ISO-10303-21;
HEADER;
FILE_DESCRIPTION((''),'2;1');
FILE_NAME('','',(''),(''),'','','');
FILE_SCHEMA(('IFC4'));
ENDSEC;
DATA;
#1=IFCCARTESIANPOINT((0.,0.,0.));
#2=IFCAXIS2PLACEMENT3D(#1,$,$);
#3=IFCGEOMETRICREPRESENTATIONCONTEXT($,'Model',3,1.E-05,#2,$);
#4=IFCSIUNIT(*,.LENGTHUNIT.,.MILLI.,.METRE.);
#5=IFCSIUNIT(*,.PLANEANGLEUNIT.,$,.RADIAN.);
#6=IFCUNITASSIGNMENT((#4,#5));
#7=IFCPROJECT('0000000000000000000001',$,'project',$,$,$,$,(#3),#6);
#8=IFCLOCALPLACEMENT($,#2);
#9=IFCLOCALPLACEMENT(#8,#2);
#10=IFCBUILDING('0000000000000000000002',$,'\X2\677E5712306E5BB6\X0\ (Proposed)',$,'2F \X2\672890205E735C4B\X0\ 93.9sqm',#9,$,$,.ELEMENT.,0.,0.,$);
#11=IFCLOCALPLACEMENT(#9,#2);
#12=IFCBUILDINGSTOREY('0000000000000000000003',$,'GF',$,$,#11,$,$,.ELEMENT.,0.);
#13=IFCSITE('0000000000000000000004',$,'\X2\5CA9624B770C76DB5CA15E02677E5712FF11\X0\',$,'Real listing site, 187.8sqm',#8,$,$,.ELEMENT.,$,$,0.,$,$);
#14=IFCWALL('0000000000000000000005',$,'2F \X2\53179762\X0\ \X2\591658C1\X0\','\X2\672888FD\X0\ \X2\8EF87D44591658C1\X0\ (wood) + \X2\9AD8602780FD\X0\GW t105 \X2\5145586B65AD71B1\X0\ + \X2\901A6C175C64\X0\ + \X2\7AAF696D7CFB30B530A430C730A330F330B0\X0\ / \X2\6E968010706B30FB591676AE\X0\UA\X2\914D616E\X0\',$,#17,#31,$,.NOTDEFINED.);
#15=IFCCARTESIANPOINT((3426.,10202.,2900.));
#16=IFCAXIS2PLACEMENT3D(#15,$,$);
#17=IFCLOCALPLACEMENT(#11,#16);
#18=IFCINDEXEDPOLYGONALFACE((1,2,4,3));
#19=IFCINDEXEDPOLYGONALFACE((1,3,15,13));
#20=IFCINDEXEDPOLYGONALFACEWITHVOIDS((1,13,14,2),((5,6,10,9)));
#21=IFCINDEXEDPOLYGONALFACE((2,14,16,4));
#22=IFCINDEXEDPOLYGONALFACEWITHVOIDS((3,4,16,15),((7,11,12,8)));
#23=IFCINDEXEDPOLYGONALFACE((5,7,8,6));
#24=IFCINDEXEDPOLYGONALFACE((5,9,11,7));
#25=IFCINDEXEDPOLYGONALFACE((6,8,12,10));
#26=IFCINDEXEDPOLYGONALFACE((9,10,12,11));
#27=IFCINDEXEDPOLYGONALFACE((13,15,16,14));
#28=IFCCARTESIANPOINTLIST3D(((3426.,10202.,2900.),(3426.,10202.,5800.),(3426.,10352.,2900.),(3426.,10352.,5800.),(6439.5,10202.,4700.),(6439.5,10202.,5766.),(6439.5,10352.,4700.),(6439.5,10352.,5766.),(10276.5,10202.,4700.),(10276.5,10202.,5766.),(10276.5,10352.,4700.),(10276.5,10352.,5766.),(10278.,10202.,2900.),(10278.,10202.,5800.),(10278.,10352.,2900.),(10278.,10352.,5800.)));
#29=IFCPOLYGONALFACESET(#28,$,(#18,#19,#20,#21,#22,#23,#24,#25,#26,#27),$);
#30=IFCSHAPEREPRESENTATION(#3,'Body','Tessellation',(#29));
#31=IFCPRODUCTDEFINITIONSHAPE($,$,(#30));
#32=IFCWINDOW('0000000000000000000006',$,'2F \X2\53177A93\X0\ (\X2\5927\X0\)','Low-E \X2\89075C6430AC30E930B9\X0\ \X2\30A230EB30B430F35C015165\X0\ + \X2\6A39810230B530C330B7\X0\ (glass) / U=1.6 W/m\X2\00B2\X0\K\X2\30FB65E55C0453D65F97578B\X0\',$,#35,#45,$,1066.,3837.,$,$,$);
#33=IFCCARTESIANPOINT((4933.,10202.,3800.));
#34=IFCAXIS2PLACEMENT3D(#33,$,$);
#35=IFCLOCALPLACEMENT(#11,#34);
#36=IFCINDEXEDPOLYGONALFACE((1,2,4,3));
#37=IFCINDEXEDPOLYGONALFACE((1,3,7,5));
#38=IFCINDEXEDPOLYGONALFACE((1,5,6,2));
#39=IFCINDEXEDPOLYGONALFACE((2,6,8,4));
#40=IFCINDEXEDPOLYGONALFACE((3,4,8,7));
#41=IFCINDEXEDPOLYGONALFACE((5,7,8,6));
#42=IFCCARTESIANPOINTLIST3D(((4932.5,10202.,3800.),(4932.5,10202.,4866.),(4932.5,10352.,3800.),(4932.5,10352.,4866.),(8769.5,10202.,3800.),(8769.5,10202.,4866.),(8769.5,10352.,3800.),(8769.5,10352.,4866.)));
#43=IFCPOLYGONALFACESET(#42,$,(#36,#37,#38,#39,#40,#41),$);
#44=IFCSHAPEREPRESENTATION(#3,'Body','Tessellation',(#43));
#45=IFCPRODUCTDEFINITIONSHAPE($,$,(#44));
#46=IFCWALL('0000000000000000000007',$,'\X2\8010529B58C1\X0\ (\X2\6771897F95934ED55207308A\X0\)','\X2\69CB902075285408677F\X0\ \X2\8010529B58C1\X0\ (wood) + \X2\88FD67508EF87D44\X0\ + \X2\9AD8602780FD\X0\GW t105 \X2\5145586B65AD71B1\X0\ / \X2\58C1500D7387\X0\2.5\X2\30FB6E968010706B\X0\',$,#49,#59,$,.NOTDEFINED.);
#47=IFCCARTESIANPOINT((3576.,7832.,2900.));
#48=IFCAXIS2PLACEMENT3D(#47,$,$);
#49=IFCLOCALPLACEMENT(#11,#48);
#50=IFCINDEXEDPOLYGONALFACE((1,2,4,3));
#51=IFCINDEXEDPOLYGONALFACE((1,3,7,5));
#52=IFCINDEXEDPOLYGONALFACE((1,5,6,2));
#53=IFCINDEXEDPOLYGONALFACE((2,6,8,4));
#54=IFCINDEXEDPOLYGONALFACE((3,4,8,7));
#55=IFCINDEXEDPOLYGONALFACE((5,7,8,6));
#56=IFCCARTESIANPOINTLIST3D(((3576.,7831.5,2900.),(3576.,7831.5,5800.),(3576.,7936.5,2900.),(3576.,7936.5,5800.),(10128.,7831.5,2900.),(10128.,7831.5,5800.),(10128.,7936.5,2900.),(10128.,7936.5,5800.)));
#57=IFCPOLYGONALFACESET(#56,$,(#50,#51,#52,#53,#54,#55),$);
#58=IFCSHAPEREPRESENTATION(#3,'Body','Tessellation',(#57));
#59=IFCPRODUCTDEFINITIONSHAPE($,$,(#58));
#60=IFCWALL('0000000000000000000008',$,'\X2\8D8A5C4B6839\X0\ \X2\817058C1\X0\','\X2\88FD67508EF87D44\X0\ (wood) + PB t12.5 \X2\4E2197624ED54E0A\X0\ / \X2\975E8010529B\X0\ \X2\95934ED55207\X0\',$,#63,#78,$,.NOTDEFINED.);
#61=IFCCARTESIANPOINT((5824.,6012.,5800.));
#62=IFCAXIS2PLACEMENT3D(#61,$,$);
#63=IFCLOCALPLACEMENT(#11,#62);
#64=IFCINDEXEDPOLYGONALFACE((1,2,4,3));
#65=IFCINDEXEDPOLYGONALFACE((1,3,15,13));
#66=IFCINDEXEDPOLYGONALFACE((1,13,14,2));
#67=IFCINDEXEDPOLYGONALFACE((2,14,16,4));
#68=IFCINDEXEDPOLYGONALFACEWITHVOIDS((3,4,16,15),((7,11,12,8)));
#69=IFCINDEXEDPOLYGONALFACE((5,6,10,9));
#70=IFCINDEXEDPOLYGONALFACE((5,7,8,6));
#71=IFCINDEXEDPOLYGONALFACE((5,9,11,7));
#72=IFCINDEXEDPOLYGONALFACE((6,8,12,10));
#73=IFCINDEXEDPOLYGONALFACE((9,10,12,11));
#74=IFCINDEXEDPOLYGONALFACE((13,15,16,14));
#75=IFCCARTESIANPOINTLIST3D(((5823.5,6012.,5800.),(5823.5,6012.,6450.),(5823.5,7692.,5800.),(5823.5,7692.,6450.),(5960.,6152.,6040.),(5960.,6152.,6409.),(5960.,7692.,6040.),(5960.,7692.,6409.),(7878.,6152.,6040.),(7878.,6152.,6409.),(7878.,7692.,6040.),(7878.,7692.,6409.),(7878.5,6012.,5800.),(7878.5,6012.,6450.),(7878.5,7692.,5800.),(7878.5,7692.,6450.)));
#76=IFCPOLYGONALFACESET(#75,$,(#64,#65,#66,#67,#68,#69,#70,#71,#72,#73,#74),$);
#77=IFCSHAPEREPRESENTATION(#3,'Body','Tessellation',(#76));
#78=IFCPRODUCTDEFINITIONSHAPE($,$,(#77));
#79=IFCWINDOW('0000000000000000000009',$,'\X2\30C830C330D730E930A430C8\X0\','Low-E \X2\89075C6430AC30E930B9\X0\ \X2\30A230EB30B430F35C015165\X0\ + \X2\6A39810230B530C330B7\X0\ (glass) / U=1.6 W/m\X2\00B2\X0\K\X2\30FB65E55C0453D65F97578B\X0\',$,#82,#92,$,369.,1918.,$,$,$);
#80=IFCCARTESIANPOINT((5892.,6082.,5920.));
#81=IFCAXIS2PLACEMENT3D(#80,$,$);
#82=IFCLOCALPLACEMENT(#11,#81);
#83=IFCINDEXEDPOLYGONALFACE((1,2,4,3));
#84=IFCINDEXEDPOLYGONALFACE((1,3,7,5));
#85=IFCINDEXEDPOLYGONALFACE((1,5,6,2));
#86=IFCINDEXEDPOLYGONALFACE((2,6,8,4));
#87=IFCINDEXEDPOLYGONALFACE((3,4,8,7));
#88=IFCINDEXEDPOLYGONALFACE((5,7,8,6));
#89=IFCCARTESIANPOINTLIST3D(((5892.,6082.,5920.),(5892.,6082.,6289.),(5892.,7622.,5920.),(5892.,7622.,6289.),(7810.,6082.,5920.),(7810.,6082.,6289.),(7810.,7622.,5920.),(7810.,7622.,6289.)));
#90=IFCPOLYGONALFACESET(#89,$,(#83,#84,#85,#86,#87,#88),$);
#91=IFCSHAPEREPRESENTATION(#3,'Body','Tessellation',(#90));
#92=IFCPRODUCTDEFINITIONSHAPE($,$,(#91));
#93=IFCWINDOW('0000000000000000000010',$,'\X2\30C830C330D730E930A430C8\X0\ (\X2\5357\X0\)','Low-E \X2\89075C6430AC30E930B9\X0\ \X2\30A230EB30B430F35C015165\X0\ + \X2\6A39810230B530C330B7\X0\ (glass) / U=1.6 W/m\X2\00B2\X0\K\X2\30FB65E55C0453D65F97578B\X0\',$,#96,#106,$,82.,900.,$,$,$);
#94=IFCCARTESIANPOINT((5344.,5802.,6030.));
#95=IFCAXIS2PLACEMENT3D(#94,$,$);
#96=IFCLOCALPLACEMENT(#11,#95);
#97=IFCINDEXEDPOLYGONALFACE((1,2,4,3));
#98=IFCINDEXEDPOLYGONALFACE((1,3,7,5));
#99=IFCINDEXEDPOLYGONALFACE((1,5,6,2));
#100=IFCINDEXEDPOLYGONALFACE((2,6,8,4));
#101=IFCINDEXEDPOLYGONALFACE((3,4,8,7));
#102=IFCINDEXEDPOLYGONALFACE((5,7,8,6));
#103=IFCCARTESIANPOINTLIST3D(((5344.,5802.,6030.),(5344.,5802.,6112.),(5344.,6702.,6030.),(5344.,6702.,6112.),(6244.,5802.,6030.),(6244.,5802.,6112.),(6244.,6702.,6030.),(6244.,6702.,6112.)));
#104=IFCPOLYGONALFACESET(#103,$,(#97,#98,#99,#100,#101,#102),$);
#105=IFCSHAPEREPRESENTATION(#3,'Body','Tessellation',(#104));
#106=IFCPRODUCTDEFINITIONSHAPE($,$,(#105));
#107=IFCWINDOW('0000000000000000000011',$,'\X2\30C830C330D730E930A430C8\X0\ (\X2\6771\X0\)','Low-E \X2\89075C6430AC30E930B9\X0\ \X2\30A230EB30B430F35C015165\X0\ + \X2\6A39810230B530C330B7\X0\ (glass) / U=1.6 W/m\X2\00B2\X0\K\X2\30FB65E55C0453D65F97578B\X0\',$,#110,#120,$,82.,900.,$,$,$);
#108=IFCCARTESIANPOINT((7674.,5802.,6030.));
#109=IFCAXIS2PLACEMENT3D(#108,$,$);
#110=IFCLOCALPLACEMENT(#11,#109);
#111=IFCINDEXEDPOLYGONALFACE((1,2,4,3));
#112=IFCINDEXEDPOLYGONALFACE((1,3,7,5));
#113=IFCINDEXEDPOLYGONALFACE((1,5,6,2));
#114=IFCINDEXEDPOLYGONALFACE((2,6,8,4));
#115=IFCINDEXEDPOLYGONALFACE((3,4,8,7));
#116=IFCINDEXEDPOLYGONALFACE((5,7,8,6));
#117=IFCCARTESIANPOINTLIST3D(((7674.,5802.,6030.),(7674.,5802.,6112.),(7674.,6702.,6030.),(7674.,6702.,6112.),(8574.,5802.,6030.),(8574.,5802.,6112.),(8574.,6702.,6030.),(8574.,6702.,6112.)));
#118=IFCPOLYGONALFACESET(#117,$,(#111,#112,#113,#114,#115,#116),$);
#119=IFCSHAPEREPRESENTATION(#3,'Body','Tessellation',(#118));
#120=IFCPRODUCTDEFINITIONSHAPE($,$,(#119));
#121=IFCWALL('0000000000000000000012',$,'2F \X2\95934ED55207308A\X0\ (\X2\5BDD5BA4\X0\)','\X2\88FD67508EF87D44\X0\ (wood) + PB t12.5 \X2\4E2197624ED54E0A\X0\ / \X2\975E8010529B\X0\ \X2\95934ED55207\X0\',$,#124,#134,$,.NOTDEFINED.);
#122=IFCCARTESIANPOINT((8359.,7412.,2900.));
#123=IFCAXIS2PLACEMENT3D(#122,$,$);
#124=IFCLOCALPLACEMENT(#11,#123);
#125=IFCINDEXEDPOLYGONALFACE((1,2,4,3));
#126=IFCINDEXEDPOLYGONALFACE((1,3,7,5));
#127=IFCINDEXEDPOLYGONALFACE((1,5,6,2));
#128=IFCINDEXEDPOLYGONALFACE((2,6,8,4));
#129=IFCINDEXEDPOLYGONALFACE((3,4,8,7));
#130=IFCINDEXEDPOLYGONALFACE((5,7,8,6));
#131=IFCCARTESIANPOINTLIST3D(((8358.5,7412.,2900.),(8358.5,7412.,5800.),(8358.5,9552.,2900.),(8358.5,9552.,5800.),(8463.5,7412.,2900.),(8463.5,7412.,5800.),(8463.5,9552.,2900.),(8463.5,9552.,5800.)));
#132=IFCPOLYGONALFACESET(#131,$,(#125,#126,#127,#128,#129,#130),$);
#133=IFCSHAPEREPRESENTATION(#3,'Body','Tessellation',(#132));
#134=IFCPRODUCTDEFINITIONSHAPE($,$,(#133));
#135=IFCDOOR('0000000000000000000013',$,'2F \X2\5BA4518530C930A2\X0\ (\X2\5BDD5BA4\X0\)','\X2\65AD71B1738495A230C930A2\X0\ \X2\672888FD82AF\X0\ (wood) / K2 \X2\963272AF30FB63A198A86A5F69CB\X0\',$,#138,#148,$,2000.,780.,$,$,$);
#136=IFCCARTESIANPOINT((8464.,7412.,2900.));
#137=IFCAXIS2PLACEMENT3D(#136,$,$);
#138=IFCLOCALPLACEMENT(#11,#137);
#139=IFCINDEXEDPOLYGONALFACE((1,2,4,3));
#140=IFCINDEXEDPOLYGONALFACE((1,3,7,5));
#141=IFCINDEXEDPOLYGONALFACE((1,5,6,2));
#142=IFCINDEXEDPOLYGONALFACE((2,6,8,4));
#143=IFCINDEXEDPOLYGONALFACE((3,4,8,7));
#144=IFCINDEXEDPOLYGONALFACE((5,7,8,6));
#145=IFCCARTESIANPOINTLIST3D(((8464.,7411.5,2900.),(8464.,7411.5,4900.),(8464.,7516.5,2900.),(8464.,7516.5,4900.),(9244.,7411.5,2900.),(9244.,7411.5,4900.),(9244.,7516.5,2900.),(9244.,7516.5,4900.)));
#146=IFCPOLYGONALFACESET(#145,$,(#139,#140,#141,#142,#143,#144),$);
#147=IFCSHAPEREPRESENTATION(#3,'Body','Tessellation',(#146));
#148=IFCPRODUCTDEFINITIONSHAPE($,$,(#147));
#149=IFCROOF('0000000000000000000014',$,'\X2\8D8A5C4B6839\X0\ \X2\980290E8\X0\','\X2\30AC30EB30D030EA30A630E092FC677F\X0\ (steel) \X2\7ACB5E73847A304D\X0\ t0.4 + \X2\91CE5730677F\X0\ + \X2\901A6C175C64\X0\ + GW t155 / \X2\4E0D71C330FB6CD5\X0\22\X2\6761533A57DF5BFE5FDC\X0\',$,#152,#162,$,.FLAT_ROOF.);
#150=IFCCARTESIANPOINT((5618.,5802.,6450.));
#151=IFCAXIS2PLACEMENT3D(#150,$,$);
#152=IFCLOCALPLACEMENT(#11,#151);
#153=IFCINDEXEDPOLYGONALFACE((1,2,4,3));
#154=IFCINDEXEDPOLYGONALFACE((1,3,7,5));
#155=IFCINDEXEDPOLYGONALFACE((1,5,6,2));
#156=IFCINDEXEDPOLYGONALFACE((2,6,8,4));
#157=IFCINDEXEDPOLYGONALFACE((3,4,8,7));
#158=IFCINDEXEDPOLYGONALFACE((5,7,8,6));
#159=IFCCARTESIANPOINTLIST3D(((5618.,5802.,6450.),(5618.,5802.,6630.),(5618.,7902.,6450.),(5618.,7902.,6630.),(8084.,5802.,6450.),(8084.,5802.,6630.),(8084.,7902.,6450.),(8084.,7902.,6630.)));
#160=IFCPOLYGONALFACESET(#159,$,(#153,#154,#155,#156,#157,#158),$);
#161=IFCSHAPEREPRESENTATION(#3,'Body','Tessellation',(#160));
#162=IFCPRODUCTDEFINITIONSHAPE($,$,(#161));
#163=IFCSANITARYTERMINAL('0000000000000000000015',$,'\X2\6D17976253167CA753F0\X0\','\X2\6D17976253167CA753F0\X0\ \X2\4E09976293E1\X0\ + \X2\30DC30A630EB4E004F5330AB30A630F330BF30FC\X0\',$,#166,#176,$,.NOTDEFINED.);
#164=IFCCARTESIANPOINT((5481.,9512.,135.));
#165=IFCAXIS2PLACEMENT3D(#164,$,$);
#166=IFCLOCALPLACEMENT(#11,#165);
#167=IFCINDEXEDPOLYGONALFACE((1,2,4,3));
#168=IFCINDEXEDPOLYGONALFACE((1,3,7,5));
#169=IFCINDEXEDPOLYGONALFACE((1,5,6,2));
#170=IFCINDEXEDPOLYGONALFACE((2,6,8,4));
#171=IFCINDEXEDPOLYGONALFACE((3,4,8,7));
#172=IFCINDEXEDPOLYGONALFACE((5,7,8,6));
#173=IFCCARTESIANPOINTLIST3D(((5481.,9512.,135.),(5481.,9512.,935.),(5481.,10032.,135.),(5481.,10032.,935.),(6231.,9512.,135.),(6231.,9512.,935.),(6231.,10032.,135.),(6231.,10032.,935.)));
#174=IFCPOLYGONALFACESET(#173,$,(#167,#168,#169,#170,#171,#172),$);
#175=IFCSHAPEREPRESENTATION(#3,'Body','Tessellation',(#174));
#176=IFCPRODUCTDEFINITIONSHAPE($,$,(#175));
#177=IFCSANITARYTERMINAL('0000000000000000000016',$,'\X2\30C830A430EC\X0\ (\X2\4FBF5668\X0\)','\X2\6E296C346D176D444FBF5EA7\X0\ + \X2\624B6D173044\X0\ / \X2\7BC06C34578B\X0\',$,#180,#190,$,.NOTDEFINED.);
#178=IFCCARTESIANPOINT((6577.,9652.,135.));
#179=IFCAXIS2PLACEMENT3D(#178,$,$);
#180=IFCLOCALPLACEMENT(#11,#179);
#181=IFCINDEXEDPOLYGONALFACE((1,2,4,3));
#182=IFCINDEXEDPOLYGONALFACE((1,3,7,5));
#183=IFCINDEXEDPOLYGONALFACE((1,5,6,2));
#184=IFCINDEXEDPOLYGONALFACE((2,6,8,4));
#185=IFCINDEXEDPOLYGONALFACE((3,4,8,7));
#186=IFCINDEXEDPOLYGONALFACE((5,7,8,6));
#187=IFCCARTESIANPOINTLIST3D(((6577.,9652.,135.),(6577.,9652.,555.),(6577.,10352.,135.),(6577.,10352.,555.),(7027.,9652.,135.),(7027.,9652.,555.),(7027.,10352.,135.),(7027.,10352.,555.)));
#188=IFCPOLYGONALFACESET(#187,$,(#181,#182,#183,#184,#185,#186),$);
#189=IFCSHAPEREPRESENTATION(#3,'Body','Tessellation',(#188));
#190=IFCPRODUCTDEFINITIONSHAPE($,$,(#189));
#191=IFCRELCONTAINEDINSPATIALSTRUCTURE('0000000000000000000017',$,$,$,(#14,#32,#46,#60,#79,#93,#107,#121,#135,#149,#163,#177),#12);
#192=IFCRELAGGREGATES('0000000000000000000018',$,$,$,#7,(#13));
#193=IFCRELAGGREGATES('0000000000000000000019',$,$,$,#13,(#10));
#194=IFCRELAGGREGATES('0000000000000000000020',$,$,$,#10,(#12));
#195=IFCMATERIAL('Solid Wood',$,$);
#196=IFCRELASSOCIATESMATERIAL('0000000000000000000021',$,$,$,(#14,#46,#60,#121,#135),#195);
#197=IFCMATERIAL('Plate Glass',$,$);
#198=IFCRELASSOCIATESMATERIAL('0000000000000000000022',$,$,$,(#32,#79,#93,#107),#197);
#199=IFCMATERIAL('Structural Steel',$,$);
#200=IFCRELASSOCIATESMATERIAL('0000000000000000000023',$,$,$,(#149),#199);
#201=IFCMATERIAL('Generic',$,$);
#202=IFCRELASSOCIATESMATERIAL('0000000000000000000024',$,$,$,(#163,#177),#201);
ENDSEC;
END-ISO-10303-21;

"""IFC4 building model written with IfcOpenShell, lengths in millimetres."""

from ifc_helpers import new_model, si_unit, frame, frame_2d, origin, place, context, project, spatial, rectangle, extrude, material, element, fill, save


model = new_model("IFC4")

# Units and contexts
model_context = context("Model", 3, precision=1e-05, world=origin())
ifc_project = project(units=[si_unit("LENGTHUNIT", "METRE", prefix="MILLI"), si_unit("PLANEANGLEUNIT", "RADIAN")], contexts=[model_context])

# Site, building, storey
site_placement = place(None, origin())
site = spatial("IfcSite", under=ifc_project, at=site_placement, Name="岩手県盛岡市松園１", ObjectType="Real listing site, 187.8sqm", CompositionType="ELEMENT", RefElevation=0.0)
building_placement = place(site_placement, origin())
building = spatial("IfcBuilding", under=site, at=building_placement, Name="松園の家 (Proposed)", ObjectType="2F 木造平屋 93.9sqm", CompositionType="ELEMENT", ElevationOfRefHeight=0.0, ElevationOfTerrain=0.0)
storey_placement = place(building_placement, origin())
storey = spatial("IfcBuildingStorey", under=building, at=storey_placement, Name="GF", CompositionType="ELEMENT", Elevation=0.0)

# Wall, opening, window
ifc_material_1 = material(Name="Solid Wood")
wall_1_placement = place(storey_placement, frame((3426.0, 10202.0, 2900.0)))
wall_1 = element("IfcWall", 1, at=wall_1_placement, inside=storey, material=ifc_material_1, Name="2F 北面 外壁", Description="木製 軸組外壁 (wood) + 高性能GW t105 充填断熱 + 通気層 + 窯業系サイディング / 準耐火・外皮UA配慮", PredefinedType="NOTDEFINED", context=model_context, shape_type="SweptSolid", body=[
    extrude(rectangle(XDim=6852.0, YDim=150.0, at=frame_2d((3426.0, 75.0))), frame((3426.0, 10202.0, 2900.0)), (0.0, 0.0, 1.0), 2900.0),
])
opening_1_placement = place(storey_placement, frame((4933.0, 10202.0, 3800.0)))
opening_1 = element("IfcOpeningElement", 2, at=opening_1_placement, cuts=wall_1, PredefinedType="NOTDEFINED", context=model_context, shape_type="SweptSolid", body=[
    extrude(rectangle(XDim=3837.0, YDim=150.0, at=frame_2d((1918.0, 75.0))), frame((4933.0, 10202.0, 3800.0)), (0.0, 0.0, 1.0), 1066.0),
])
ifc_material_2 = material(Name="Plate Glass")
window_1_placement = place(storey_placement, frame((4933.0, 10202.0, 3800.0)))
window_1 = element("IfcWindow", 3, at=window_1_placement, inside=storey, material=ifc_material_2, Name="2F 北窓 (大)", Description="Low-E 複層ガラス アルゴン封入 + 樹脂サッシ (glass) / U=1.6 W/m²K・日射取得型", OverallHeight=1066.0, OverallWidth=3837.0, context=model_context, shape_type="SweptSolid", body=[
    extrude(rectangle(XDim=3837.0, YDim=150.0, at=frame_2d((1918.0, 75.0))), frame((4933.0, 10202.0, 3800.0)), (0.0, 0.0, 1.0), 1066.0),
])
fill(opening_1, window_1)

# Wall
wall_2_placement = place(storey_placement, frame((3576.0, 7832.0, 2900.0)))
element("IfcWall", 4, at=wall_2_placement, inside=storey, material=ifc_material_1, Name="耐力壁 (東西間仕切り)", Description="構造用合板 耐力壁 (wood) + 製材軸組 + 高性能GW t105 充填断熱 / 壁倍率2.5・準耐火", PredefinedType="NOTDEFINED", context=model_context, shape_type="SweptSolid", body=[
    extrude(rectangle(XDim=6552.0, YDim=105.0, at=frame_2d((3276.0, 52.0))), frame((3576.0, 7832.0, 2900.0)), (0.0, 0.0, 1.0), 2900.0),
])

# Wall, openings, windows
wall_3_placement = place(storey_placement, frame((5824.0, 6012.0, 5800.0)))
wall_3 = element("IfcWall", 5, at=wall_3_placement, inside=storey, material=ifc_material_1, Name="越屋根 腰壁", Description="製材軸組 (wood) + PB t12.5 両面仕上 / 非耐力 間仕切", PredefinedType="NOTDEFINED", context=model_context, shape_type="SweptSolid", body=[
    extrude(rectangle(XDim=2055.0, YDim=1680.0, at=frame_2d((1027.0, 840.0))), frame((5824.0, 6012.0, 5800.0)), (0.0, 0.0, 1.0), 650.0),
])
opening_2_placement = place(storey_placement, frame((5892.0, 6082.0, 5920.0)))
opening_2 = element("IfcOpeningElement", 6, at=opening_2_placement, cuts=wall_3, PredefinedType="NOTDEFINED", context=model_context, shape_type="SweptSolid", body=[
    extrude(rectangle(XDim=1918.0, YDim=1540.0, at=frame_2d((959.0, 770.0))), frame((5892.0, 6082.0, 5920.0)), (0.0, 0.0, 1.0), 369.0),
])
opening_3_placement = place(storey_placement, frame((5344.0, 5802.0, 6030.0)))
opening_3 = element("IfcOpeningElement", 7, at=opening_3_placement, cuts=wall_3, PredefinedType="NOTDEFINED", context=model_context, shape_type="SweptSolid", body=[
    extrude(rectangle(XDim=900.0, YDim=900.0, at=frame_2d((450.0, 450.0))), frame((5344.0, 5802.0, 6030.0)), (0.0, 0.0, 1.0), 82.0),
])
opening_4_placement = place(storey_placement, frame((7674.0, 5802.0, 6030.0)))
opening_4 = element("IfcOpeningElement", 8, at=opening_4_placement, cuts=wall_3, PredefinedType="NOTDEFINED", context=model_context, shape_type="SweptSolid", body=[
    extrude(rectangle(XDim=900.0, YDim=900.0, at=frame_2d((450.0, 450.0))), frame((7674.0, 5802.0, 6030.0)), (0.0, 0.0, 1.0), 82.0),
])
window_2_placement = place(storey_placement, frame((5892.0, 6082.0, 5920.0)))
window_2 = element("IfcWindow", 9, at=window_2_placement, inside=storey, material=ifc_material_2, Name="トップライト", Description="Low-E 複層ガラス アルゴン封入 + 樹脂サッシ (glass) / U=1.6 W/m²K・日射取得型", OverallHeight=369.0, OverallWidth=1918.0, context=model_context, shape_type="SweptSolid", body=[
    extrude(rectangle(XDim=1918.0, YDim=1540.0, at=frame_2d((959.0, 770.0))), frame((5892.0, 6082.0, 5920.0)), (0.0, 0.0, 1.0), 369.0),
])
fill(opening_2, window_2)
window_3_placement = place(storey_placement, frame((5344.0, 5802.0, 6030.0)))
window_3 = element("IfcWindow", 10, at=window_3_placement, inside=storey, material=ifc_material_2, Name="トップライト (南)", Description="Low-E 複層ガラス アルゴン封入 + 樹脂サッシ (glass) / U=1.6 W/m²K・日射取得型", OverallHeight=82.0, OverallWidth=900.0, context=model_context, shape_type="SweptSolid", body=[
    extrude(rectangle(XDim=900.0, YDim=900.0, at=frame_2d((450.0, 450.0))), frame((5344.0, 5802.0, 6030.0)), (0.0, 0.0, 1.0), 82.0),
])
fill(opening_3, window_3)
window_4_placement = place(storey_placement, frame((7674.0, 5802.0, 6030.0)))
window_4 = element("IfcWindow", 11, at=window_4_placement, inside=storey, material=ifc_material_2, Name="トップライト (東)", Description="Low-E 複層ガラス アルゴン封入 + 樹脂サッシ (glass) / U=1.6 W/m²K・日射取得型", OverallHeight=82.0, OverallWidth=900.0, context=model_context, shape_type="SweptSolid", body=[
    extrude(rectangle(XDim=900.0, YDim=900.0, at=frame_2d((450.0, 450.0))), frame((7674.0, 5802.0, 6030.0)), (0.0, 0.0, 1.0), 82.0),
])
fill(opening_4, window_4)

# Wall
wall_4_placement = place(storey_placement, frame((8359.0, 7412.0, 2900.0)))
element("IfcWall", 12, at=wall_4_placement, inside=storey, material=ifc_material_1, Name="2F 間仕切り (寝室)", Description="製材軸組 (wood) + PB t12.5 両面仕上 / 非耐力 間仕切", PredefinedType="NOTDEFINED", context=model_context, shape_type="SweptSolid", body=[
    extrude(rectangle(XDim=105.0, YDim=2140.0, at=frame_2d((52.0, 1070.0))), frame((8359.0, 7412.0, 2900.0)), (0.0, 0.0, 1.0), 2900.0),
])

# Door
door_placement = place(storey_placement, frame((8464.0, 7412.0, 2900.0)))
element("IfcDoor", 13, at=door_placement, inside=storey, material=ifc_material_1, Name="2F 室内ドア (寝室)", Description="断熱玄関ドア 木製芯 (wood) / K2 防犯・採風機構", OverallHeight=2000.0, OverallWidth=780.0, context=model_context, shape_type="SweptSolid", body=[
    extrude(rectangle(XDim=780.0, YDim=105.0, at=frame_2d((390.0, 52.0))), frame((8464.0, 7412.0, 2900.0)), (0.0, 0.0, 1.0), 2000.0),
])

# Roof
ifc_material_3 = material(Name="Structural Steel")
roof_placement = place(storey_placement, frame((5618.0, 5802.0, 6450.0)))
element("IfcRoof", 14, at=roof_placement, inside=storey, material=ifc_material_3, Name="越屋根 頂部", Description="ガルバリウム鋼板 (steel) 立平葺き t0.4 + 野地板 + 通気層 + GW t155 / 不燃・法22条区域対応", PredefinedType="FLAT_ROOF", context=model_context, shape_type="SweptSolid", body=[
    extrude(rectangle(XDim=2466.0, YDim=2100.0, at=frame_2d((1233.0, 1050.0))), frame((5618.0, 5802.0, 6450.0)), (0.0, 0.0, 1.0), 180.0),
])

# Sanitary terminals
ifc_material_4 = material(Name="Generic")
sanitary_terminal_1_placement = place(storey_placement, frame((5481.0, 9512.0, 135.0)))
element("IfcSanitaryTerminal", 15, at=sanitary_terminal_1_placement, inside=storey, material=ifc_material_4, Name="洗面化粧台", Description="洗面化粧台 三面鏡 + ボウル一体カウンター", PredefinedType="NOTDEFINED", context=model_context, shape_type="SweptSolid", body=[
    extrude(rectangle(XDim=750.0, YDim=520.0, at=frame_2d((375.0, 260.0))), frame((5481.0, 9512.0, 135.0)), (0.0, 0.0, 1.0), 800.0),
])
sanitary_terminal_2_placement = place(storey_placement, frame((6577.0, 9652.0, 135.0)))
element("IfcSanitaryTerminal", 16, at=sanitary_terminal_2_placement, inside=storey, material=ifc_material_4, Name="トイレ (便器)", Description="温水洗浄便座 + 手洗い / 節水型", PredefinedType="NOTDEFINED", context=model_context, shape_type="SweptSolid", body=[
    extrude(rectangle(XDim=450.0, YDim=700.0, at=frame_2d((225.0, 350.0))), frame((6577.0, 9652.0, 135.0)), (0.0, 0.0, 1.0), 420.0),
])

save(model, "model.ifc")
